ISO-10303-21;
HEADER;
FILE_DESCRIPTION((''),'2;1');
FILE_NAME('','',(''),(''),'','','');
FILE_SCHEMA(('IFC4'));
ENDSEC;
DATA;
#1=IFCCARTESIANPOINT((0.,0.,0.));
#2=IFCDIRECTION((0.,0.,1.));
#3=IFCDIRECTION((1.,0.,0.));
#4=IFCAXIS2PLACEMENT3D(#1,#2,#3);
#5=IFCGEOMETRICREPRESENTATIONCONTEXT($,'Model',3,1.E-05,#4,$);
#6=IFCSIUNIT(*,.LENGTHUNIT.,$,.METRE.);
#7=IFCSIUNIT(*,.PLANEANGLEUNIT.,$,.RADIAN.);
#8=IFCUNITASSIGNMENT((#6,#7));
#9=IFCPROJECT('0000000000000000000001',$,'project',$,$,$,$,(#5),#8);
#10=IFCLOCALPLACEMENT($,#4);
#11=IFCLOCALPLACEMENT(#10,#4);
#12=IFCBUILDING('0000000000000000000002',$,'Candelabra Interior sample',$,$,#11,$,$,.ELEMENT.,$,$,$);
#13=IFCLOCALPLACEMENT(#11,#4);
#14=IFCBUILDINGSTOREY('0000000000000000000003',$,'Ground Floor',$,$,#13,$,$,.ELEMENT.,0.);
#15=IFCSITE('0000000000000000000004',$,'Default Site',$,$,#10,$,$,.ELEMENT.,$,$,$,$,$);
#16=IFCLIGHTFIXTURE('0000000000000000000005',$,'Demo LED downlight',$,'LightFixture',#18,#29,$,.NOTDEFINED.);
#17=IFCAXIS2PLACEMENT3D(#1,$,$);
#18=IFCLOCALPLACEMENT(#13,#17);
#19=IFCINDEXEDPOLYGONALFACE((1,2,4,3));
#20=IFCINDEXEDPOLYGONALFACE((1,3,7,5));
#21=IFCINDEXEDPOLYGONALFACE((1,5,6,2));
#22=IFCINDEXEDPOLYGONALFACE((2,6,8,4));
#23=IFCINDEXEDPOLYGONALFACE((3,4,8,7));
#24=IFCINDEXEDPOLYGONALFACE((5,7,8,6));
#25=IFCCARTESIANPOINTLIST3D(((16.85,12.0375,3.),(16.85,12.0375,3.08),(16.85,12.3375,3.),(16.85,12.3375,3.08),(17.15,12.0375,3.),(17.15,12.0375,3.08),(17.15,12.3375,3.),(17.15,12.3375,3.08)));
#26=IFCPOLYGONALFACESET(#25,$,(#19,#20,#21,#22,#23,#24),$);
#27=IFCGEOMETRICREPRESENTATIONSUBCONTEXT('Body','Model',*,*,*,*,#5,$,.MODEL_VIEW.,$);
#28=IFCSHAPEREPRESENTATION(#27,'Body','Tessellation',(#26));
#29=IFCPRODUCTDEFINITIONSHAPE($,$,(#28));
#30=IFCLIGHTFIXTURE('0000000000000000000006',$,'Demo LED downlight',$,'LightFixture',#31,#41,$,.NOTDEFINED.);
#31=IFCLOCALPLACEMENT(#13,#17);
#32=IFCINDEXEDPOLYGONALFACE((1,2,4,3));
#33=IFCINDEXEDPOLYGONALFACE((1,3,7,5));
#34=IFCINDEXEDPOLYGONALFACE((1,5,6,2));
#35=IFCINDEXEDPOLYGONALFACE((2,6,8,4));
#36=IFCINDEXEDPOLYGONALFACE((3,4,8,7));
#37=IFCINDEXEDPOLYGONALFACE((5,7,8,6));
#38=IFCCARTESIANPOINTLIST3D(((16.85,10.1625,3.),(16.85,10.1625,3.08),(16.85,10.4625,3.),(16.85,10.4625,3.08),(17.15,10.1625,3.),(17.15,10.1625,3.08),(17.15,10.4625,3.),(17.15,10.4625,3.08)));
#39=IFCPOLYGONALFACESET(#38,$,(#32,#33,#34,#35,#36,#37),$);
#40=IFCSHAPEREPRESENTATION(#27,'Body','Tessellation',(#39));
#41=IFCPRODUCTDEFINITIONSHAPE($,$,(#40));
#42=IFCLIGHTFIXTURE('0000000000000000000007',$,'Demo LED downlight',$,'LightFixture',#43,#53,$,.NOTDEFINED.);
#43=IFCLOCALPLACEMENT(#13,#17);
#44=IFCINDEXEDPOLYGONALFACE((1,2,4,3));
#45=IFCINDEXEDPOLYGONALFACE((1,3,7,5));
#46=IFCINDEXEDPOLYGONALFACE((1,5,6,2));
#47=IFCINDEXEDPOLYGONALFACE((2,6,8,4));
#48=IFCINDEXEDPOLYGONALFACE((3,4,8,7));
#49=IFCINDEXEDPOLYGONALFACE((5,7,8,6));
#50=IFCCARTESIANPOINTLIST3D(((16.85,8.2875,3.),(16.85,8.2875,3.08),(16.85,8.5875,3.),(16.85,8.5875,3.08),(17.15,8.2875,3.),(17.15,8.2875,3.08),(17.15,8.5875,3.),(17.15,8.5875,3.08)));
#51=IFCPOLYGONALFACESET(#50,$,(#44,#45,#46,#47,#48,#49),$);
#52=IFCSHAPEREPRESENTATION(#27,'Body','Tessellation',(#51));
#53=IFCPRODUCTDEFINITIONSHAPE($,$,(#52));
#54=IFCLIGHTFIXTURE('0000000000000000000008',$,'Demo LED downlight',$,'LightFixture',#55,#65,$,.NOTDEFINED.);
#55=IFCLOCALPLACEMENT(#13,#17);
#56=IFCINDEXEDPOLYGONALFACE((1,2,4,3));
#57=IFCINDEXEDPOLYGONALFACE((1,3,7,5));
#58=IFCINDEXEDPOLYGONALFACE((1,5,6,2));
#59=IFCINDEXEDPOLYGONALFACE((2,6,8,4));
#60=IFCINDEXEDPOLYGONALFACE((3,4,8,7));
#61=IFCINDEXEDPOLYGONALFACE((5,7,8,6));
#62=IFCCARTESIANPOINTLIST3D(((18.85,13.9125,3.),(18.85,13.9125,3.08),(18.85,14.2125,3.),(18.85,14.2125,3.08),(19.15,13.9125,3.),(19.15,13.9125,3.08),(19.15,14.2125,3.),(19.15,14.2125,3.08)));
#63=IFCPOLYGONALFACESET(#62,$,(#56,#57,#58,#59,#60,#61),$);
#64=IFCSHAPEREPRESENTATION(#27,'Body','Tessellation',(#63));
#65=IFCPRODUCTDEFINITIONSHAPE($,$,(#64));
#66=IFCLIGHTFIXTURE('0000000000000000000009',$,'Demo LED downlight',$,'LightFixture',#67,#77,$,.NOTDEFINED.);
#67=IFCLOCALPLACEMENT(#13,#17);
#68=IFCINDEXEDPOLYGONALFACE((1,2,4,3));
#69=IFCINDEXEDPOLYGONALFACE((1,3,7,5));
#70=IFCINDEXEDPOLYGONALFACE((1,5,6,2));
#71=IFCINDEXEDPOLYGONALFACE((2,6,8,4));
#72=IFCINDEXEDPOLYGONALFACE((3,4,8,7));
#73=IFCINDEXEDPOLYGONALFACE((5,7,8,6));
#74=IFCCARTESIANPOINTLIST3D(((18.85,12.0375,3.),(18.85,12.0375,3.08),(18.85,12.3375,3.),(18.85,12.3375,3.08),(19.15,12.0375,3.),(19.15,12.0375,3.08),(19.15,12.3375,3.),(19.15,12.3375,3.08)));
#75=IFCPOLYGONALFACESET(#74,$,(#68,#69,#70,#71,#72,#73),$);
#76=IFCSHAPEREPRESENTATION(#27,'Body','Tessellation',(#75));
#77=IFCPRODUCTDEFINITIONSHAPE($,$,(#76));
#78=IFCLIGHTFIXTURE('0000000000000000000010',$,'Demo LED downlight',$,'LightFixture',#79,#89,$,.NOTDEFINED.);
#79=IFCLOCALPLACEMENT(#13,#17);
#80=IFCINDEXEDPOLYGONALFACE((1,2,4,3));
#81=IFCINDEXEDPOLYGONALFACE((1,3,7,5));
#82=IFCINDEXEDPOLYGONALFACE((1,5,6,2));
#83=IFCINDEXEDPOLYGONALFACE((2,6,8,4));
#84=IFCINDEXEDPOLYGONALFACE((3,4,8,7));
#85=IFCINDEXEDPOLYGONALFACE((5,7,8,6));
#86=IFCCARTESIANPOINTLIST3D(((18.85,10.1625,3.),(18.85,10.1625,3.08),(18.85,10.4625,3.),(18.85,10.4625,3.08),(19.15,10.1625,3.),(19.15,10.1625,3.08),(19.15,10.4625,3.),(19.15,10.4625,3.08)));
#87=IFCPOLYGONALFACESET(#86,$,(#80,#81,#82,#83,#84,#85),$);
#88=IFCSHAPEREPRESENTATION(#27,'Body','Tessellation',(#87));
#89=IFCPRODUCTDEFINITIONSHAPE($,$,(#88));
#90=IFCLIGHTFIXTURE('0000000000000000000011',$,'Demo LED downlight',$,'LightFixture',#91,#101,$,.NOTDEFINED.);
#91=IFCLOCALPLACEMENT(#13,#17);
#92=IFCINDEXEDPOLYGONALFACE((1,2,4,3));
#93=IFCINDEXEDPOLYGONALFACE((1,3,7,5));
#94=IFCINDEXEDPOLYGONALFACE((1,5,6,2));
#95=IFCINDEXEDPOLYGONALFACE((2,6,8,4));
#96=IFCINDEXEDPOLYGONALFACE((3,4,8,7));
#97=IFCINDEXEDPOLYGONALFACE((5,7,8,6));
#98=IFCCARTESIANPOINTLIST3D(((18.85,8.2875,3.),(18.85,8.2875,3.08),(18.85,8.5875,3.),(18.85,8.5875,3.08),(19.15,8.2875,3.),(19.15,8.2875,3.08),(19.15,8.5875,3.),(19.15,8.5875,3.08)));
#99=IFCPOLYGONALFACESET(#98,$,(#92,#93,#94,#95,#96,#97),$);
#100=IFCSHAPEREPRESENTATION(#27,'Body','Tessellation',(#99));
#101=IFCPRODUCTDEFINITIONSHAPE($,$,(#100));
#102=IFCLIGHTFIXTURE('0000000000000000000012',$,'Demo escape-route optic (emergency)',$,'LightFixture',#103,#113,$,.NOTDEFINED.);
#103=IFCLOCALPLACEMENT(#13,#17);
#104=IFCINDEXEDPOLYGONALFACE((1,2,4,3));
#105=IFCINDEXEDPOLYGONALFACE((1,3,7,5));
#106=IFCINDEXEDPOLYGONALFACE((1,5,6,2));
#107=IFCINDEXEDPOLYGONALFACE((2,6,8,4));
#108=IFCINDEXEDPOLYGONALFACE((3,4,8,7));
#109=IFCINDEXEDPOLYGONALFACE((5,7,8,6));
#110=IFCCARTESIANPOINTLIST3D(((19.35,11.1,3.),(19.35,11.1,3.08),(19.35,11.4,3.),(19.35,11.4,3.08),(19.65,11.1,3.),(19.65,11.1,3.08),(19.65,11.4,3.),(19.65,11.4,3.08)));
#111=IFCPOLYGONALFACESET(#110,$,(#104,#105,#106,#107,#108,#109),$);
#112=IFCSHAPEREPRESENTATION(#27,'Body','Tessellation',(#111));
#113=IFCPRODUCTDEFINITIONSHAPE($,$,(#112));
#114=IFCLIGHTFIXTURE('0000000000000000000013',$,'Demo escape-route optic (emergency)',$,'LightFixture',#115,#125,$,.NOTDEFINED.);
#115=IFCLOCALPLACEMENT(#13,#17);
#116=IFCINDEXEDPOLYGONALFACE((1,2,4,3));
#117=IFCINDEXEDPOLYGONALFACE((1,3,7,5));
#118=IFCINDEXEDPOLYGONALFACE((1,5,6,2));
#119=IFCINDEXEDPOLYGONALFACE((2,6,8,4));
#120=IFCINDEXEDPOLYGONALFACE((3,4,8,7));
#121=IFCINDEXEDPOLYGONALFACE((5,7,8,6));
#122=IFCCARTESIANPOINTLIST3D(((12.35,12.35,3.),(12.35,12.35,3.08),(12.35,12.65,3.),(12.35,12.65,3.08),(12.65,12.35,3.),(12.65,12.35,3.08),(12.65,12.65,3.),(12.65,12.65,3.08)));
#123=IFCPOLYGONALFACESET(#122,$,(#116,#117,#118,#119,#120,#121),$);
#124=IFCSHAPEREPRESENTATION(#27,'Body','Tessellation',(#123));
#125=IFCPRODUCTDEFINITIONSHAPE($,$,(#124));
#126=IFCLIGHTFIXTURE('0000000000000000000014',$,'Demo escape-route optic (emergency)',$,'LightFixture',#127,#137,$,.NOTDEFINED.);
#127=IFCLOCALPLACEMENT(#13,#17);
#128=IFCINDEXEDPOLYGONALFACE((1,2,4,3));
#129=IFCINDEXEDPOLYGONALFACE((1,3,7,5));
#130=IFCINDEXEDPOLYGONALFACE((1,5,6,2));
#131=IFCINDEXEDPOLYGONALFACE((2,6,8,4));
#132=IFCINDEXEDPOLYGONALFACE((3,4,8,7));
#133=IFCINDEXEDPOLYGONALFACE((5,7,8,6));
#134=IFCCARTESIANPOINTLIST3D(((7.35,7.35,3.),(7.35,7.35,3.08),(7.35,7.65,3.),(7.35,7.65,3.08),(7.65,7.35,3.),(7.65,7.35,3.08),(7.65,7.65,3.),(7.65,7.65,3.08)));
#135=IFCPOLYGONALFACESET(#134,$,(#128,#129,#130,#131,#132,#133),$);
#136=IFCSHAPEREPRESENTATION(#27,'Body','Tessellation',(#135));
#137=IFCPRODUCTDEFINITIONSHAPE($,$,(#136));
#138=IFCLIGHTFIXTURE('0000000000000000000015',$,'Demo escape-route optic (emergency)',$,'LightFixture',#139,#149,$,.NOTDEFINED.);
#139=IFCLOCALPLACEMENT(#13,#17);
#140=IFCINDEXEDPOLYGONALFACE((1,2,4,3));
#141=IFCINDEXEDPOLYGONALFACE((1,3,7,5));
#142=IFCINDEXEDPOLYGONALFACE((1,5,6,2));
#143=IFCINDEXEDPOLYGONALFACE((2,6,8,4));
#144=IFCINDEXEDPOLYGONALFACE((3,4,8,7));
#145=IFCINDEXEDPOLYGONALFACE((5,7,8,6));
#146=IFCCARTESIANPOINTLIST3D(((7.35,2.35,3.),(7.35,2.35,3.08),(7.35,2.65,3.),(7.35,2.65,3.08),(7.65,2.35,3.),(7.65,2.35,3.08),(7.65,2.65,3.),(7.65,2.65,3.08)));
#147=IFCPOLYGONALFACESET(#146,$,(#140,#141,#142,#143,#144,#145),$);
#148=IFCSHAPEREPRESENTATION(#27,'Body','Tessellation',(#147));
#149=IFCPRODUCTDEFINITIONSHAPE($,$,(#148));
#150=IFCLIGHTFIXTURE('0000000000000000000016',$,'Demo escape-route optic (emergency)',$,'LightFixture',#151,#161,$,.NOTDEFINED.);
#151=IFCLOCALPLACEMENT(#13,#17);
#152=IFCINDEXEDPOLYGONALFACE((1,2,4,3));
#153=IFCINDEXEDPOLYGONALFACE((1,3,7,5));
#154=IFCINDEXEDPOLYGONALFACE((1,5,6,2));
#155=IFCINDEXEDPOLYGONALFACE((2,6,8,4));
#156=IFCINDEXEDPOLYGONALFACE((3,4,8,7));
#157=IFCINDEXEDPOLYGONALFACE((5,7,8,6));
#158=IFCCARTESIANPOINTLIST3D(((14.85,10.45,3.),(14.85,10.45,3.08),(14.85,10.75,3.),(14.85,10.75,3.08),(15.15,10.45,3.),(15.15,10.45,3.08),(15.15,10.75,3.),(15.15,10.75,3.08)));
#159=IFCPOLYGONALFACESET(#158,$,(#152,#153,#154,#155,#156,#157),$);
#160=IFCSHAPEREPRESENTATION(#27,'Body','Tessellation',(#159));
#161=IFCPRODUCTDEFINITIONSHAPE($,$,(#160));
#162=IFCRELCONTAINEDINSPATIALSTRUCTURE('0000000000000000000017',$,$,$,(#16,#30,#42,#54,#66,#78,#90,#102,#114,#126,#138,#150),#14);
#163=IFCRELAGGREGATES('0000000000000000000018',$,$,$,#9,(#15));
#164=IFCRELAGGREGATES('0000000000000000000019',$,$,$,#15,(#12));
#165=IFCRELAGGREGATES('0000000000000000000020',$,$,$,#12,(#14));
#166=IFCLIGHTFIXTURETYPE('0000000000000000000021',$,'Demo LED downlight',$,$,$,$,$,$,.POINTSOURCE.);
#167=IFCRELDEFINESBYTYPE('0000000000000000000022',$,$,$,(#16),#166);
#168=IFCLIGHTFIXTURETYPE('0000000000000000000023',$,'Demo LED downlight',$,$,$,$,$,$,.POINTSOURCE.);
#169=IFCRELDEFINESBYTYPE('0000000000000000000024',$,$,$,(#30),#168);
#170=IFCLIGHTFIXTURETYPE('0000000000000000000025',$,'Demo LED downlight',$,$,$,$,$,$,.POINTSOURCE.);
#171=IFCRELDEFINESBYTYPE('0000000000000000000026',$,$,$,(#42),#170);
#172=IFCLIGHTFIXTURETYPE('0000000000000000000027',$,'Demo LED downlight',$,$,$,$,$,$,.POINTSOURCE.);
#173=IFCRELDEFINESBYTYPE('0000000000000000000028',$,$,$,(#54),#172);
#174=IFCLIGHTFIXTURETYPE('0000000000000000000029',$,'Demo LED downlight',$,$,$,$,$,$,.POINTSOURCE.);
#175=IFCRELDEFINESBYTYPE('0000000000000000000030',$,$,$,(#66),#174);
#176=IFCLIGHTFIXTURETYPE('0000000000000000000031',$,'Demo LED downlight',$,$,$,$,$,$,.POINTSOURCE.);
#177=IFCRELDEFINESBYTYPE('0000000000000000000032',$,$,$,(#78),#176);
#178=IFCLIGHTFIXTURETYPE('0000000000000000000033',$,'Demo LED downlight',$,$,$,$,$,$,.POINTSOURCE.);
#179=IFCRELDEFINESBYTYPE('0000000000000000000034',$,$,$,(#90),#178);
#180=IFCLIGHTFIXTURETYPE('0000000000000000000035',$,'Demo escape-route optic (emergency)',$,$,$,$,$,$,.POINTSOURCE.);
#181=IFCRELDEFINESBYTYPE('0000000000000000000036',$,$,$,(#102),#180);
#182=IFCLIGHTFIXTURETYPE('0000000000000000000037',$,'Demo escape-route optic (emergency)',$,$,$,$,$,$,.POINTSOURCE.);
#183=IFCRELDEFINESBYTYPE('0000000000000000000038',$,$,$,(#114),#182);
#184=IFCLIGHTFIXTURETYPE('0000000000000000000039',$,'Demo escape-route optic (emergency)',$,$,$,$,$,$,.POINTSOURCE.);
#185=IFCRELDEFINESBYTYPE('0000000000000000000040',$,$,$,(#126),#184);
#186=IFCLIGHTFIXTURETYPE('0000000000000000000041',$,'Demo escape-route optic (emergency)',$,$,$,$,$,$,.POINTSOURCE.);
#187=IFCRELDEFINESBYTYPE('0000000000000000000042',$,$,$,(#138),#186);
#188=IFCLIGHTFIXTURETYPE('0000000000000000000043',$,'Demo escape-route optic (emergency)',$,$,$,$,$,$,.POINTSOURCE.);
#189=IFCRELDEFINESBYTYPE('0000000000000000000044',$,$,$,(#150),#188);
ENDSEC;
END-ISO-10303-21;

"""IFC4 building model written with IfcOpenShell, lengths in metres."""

from ifc_helpers import new_model, si_unit, frame, origin_with_axes, place, context, subcontext, project, spatial, polyline, outline, extrude, type_object, element, save


model = new_model("IFC4")

# Units and contexts
model_context = context("Model", 3, precision=1e-05, world=origin_with_axes())
body_context = subcontext(model_context, "Body", "Model", "MODEL_VIEW")
ifc_project = project(units=[si_unit("LENGTHUNIT", "METRE"), si_unit("PLANEANGLEUNIT", "RADIAN")], contexts=[model_context])

# Site, building, storey
site_placement = place(None, origin_with_axes())
site = spatial("IfcSite", under=ifc_project, at=site_placement, Name="Default Site", CompositionType="ELEMENT")
building_placement = place(site_placement, origin_with_axes())
building = spatial("IfcBuilding", under=site, at=building_placement, Name="Candelabra Interior sample", CompositionType="ELEMENT")
storey_placement = place(building_placement, origin_with_axes())
storey = spatial("IfcBuildingStorey", under=building, at=storey_placement, Name="Ground Floor", CompositionType="ELEMENT", Elevation=0.0)

# Light fixtures
light_fixture_type_1 = type_object("IfcLightFixtureType", Name="Demo LED downlight", PredefinedType="POINTSOURCE")
light_fixture_1_placement = place(storey_placement, frame((17.0, 12.1875, 3.08), z_axis=(0.0, 0.0, 1.0), x_axis=(1.0, 0.0, 0.0)))
element("IfcLightFixture", 1, at=light_fixture_1_placement, inside=storey, type_object=light_fixture_type_1, Name="Demo LED downlight", ObjectType="LightFixture", PredefinedType="NOTDEFINED", context=body_context, shape_type="SweptSolid", body=[
    extrude(outline(polyline([(0.15, 0.15), (-0.15, 0.15), (-0.15, -0.15), (0.15, -0.15), (0.15, 0.15)])), origin_with_axes(), (0.0, 0.0, -1.0), 0.08),
])
light_fixture_type_2 = type_object("IfcLightFixtureType", Name="Demo LED downlight", PredefinedType="POINTSOURCE")
light_fixture_2_placement = place(storey_placement, frame((17.0, 10.3125, 3.08), z_axis=(0.0, 0.0, 1.0), x_axis=(1.0, 0.0, 0.0)))
element("IfcLightFixture", 2, at=light_fixture_2_placement, inside=storey, type_object=light_fixture_type_2, Name="Demo LED downlight", ObjectType="LightFixture", PredefinedType="NOTDEFINED", context=body_context, shape_type="SweptSolid", body=[
    extrude(outline(polyline([(0.15, 0.15), (-0.15, 0.15), (-0.15, -0.15), (0.15, -0.15), (0.15, 0.15)])), origin_with_axes(), (0.0, 0.0, -1.0), 0.08),
])
light_fixture_type_3 = type_object("IfcLightFixtureType", Name="Demo LED downlight", PredefinedType="POINTSOURCE")
light_fixture_3_placement = place(storey_placement, frame((17.0, 8.4375, 3.08), z_axis=(0.0, 0.0, 1.0), x_axis=(1.0, 0.0, 0.0)))
element("IfcLightFixture", 3, at=light_fixture_3_placement, inside=storey, type_object=light_fixture_type_3, Name="Demo LED downlight", ObjectType="LightFixture", PredefinedType="NOTDEFINED", context=body_context, shape_type="SweptSolid", body=[
    extrude(outline(polyline([(0.15, 0.15), (-0.15, 0.15), (-0.15, -0.15), (0.15, -0.15), (0.15, 0.15)])), origin_with_axes(), (0.0, 0.0, -1.0), 0.08),
])
light_fixture_type_4 = type_object("IfcLightFixtureType", Name="Demo LED downlight", PredefinedType="POINTSOURCE")
light_fixture_4_placement = place(storey_placement, frame((19.0, 14.0625, 3.08), z_axis=(0.0, 0.0, 1.0), x_axis=(1.0, 0.0, 0.0)))
element("IfcLightFixture", 4, at=light_fixture_4_placement, inside=storey, type_object=light_fixture_type_4, Name="Demo LED downlight", ObjectType="LightFixture", PredefinedType="NOTDEFINED", context=body_context, shape_type="SweptSolid", body=[
    extrude(outline(polyline([(0.15, 0.15), (-0.15, 0.15), (-0.15, -0.15), (0.15, -0.15), (0.15, 0.15)])), origin_with_axes(), (0.0, 0.0, -1.0), 0.08),
])
light_fixture_type_5 = type_object("IfcLightFixtureType", Name="Demo LED downlight", PredefinedType="POINTSOURCE")
light_fixture_5_placement = place(storey_placement, frame((19.0, 12.1875, 3.08), z_axis=(0.0, 0.0, 1.0), x_axis=(1.0, 0.0, 0.0)))
element("IfcLightFixture", 5, at=light_fixture_5_placement, inside=storey, type_object=light_fixture_type_5, Name="Demo LED downlight", ObjectType="LightFixture", PredefinedType="NOTDEFINED", context=body_context, shape_type="SweptSolid", body=[
    extrude(outline(polyline([(0.15, 0.15), (-0.15, 0.15), (-0.15, -0.15), (0.15, -0.15), (0.15, 0.15)])), origin_with_axes(), (0.0, 0.0, -1.0), 0.08),
])
light_fixture_type_6 = type_object("IfcLightFixtureType", Name="Demo LED downlight", PredefinedType="POINTSOURCE")
light_fixture_6_placement = place(storey_placement, frame((19.0, 10.3125, 3.08), z_axis=(0.0, 0.0, 1.0), x_axis=(1.0, 0.0, 0.0)))
element("IfcLightFixture", 6, at=light_fixture_6_placement, inside=storey, type_object=light_fixture_type_6, Name="Demo LED downlight", ObjectType="LightFixture", PredefinedType="NOTDEFINED", context=body_context, shape_type="SweptSolid", body=[
    extrude(outline(polyline([(0.15, 0.15), (-0.15, 0.15), (-0.15, -0.15), (0.15, -0.15), (0.15, 0.15)])), origin_with_axes(), (0.0, 0.0, -1.0), 0.08),
])
light_fixture_type_7 = type_object("IfcLightFixtureType", Name="Demo LED downlight", PredefinedType="POINTSOURCE")
light_fixture_7_placement = place(storey_placement, frame((19.0, 8.4375, 3.08), z_axis=(0.0, 0.0, 1.0), x_axis=(1.0, 0.0, 0.0)))
element("IfcLightFixture", 7, at=light_fixture_7_placement, inside=storey, type_object=light_fixture_type_7, Name="Demo LED downlight", ObjectType="LightFixture", PredefinedType="NOTDEFINED", context=body_context, shape_type="SweptSolid", body=[
    extrude(outline(polyline([(0.15, 0.15), (-0.15, 0.15), (-0.15, -0.15), (0.15, -0.15), (0.15, 0.15)])), origin_with_axes(), (0.0, 0.0, -1.0), 0.08),
])
light_fixture_type_8 = type_object("IfcLightFixtureType", Name="Demo escape-route optic (emergency)", PredefinedType="POINTSOURCE")
light_fixture_8_placement = place(storey_placement, frame((19.5, 11.25, 3.08), z_axis=(0.0, 0.0, 1.0), x_axis=(-1.0, 0.0, 0.0)))
element("IfcLightFixture", 8, at=light_fixture_8_placement, inside=storey, type_object=light_fixture_type_8, Name="Demo escape-route optic (emergency)", ObjectType="LightFixture", PredefinedType="NOTDEFINED", context=body_context, shape_type="SweptSolid", body=[
    extrude(outline(polyline([(0.15, 0.15), (-0.15, 0.15), (-0.15, -0.15), (0.15, -0.15), (0.15, 0.15)])), origin_with_axes(), (0.0, 0.0, -1.0), 0.08),
])
light_fixture_type_9 = type_object("IfcLightFixtureType", Name="Demo escape-route optic (emergency)", PredefinedType="POINTSOURCE")
light_fixture_9_placement = place(storey_placement, frame((12.5, 12.5, 3.08), z_axis=(0.0, 0.0, 1.0), x_axis=(1.0, 0.0, 0.0)))
element("IfcLightFixture", 9, at=light_fixture_9_placement, inside=storey, type_object=light_fixture_type_9, Name="Demo escape-route optic (emergency)", ObjectType="LightFixture", PredefinedType="NOTDEFINED", context=body_context, shape_type="SweptSolid", body=[
    extrude(outline(polyline([(0.15, 0.15), (-0.15, 0.15), (-0.15, -0.15), (0.15, -0.15), (0.15, 0.15)])), origin_with_axes(), (0.0, 0.0, -1.0), 0.08),
])
light_fixture_type_10 = type_object("IfcLightFixtureType", Name="Demo escape-route optic (emergency)", PredefinedType="POINTSOURCE")
light_fixture_10_placement = place(storey_placement, frame((7.5, 7.5, 3.08), z_axis=(0.0, 0.0, 1.0), x_axis=(1.0, 0.0, 0.0)))
element("IfcLightFixture", 10, at=light_fixture_10_placement, inside=storey, type_object=light_fixture_type_10, Name="Demo escape-route optic (emergency)", ObjectType="LightFixture", PredefinedType="NOTDEFINED", context=body_context, shape_type="SweptSolid", body=[
    extrude(outline(polyline([(0.15, 0.15), (-0.15, 0.15), (-0.15, -0.15), (0.15, -0.15), (0.15, 0.15)])), origin_with_axes(), (0.0, 0.0, -1.0), 0.08),
])
light_fixture_type_11 = type_object("IfcLightFixtureType", Name="Demo escape-route optic (emergency)", PredefinedType="POINTSOURCE")
light_fixture_11_placement = place(storey_placement, frame((7.5, 2.5, 3.08), z_axis=(0.0, 0.0, 1.0), x_axis=(1.0, 0.0, 0.0)))
element("IfcLightFixture", 11, at=light_fixture_11_placement, inside=storey, type_object=light_fixture_type_11, Name="Demo escape-route optic (emergency)", ObjectType="LightFixture", PredefinedType="NOTDEFINED", context=body_context, shape_type="SweptSolid", body=[
    extrude(outline(polyline([(0.15, 0.15), (-0.15, 0.15), (-0.15, -0.15), (0.15, -0.15), (0.15, 0.15)])), origin_with_axes(), (0.0, 0.0, -1.0), 0.08),
])
light_fixture_type_12 = type_object("IfcLightFixtureType", Name="Demo escape-route optic (emergency)", PredefinedType="POINTSOURCE")
light_fixture_12_placement = place(storey_placement, frame((15.0, 10.6, 3.08), z_axis=(0.0, 0.0, 1.0), x_axis=(0.0, -1.0, 0.0)))
element("IfcLightFixture", 12, at=light_fixture_12_placement, inside=storey, type_object=light_fixture_type_12, Name="Demo escape-route optic (emergency)", ObjectType="LightFixture", PredefinedType="NOTDEFINED", context=body_context, shape_type="SweptSolid", body=[
    extrude(outline(polyline([(0.15, 0.15), (-0.15, 0.15), (-0.15, -0.15), (0.15, -0.15), (0.15, 0.15)])), origin_with_axes(), (0.0, 0.0, -1.0), 0.08),
])

save(model, "model.ifc")
